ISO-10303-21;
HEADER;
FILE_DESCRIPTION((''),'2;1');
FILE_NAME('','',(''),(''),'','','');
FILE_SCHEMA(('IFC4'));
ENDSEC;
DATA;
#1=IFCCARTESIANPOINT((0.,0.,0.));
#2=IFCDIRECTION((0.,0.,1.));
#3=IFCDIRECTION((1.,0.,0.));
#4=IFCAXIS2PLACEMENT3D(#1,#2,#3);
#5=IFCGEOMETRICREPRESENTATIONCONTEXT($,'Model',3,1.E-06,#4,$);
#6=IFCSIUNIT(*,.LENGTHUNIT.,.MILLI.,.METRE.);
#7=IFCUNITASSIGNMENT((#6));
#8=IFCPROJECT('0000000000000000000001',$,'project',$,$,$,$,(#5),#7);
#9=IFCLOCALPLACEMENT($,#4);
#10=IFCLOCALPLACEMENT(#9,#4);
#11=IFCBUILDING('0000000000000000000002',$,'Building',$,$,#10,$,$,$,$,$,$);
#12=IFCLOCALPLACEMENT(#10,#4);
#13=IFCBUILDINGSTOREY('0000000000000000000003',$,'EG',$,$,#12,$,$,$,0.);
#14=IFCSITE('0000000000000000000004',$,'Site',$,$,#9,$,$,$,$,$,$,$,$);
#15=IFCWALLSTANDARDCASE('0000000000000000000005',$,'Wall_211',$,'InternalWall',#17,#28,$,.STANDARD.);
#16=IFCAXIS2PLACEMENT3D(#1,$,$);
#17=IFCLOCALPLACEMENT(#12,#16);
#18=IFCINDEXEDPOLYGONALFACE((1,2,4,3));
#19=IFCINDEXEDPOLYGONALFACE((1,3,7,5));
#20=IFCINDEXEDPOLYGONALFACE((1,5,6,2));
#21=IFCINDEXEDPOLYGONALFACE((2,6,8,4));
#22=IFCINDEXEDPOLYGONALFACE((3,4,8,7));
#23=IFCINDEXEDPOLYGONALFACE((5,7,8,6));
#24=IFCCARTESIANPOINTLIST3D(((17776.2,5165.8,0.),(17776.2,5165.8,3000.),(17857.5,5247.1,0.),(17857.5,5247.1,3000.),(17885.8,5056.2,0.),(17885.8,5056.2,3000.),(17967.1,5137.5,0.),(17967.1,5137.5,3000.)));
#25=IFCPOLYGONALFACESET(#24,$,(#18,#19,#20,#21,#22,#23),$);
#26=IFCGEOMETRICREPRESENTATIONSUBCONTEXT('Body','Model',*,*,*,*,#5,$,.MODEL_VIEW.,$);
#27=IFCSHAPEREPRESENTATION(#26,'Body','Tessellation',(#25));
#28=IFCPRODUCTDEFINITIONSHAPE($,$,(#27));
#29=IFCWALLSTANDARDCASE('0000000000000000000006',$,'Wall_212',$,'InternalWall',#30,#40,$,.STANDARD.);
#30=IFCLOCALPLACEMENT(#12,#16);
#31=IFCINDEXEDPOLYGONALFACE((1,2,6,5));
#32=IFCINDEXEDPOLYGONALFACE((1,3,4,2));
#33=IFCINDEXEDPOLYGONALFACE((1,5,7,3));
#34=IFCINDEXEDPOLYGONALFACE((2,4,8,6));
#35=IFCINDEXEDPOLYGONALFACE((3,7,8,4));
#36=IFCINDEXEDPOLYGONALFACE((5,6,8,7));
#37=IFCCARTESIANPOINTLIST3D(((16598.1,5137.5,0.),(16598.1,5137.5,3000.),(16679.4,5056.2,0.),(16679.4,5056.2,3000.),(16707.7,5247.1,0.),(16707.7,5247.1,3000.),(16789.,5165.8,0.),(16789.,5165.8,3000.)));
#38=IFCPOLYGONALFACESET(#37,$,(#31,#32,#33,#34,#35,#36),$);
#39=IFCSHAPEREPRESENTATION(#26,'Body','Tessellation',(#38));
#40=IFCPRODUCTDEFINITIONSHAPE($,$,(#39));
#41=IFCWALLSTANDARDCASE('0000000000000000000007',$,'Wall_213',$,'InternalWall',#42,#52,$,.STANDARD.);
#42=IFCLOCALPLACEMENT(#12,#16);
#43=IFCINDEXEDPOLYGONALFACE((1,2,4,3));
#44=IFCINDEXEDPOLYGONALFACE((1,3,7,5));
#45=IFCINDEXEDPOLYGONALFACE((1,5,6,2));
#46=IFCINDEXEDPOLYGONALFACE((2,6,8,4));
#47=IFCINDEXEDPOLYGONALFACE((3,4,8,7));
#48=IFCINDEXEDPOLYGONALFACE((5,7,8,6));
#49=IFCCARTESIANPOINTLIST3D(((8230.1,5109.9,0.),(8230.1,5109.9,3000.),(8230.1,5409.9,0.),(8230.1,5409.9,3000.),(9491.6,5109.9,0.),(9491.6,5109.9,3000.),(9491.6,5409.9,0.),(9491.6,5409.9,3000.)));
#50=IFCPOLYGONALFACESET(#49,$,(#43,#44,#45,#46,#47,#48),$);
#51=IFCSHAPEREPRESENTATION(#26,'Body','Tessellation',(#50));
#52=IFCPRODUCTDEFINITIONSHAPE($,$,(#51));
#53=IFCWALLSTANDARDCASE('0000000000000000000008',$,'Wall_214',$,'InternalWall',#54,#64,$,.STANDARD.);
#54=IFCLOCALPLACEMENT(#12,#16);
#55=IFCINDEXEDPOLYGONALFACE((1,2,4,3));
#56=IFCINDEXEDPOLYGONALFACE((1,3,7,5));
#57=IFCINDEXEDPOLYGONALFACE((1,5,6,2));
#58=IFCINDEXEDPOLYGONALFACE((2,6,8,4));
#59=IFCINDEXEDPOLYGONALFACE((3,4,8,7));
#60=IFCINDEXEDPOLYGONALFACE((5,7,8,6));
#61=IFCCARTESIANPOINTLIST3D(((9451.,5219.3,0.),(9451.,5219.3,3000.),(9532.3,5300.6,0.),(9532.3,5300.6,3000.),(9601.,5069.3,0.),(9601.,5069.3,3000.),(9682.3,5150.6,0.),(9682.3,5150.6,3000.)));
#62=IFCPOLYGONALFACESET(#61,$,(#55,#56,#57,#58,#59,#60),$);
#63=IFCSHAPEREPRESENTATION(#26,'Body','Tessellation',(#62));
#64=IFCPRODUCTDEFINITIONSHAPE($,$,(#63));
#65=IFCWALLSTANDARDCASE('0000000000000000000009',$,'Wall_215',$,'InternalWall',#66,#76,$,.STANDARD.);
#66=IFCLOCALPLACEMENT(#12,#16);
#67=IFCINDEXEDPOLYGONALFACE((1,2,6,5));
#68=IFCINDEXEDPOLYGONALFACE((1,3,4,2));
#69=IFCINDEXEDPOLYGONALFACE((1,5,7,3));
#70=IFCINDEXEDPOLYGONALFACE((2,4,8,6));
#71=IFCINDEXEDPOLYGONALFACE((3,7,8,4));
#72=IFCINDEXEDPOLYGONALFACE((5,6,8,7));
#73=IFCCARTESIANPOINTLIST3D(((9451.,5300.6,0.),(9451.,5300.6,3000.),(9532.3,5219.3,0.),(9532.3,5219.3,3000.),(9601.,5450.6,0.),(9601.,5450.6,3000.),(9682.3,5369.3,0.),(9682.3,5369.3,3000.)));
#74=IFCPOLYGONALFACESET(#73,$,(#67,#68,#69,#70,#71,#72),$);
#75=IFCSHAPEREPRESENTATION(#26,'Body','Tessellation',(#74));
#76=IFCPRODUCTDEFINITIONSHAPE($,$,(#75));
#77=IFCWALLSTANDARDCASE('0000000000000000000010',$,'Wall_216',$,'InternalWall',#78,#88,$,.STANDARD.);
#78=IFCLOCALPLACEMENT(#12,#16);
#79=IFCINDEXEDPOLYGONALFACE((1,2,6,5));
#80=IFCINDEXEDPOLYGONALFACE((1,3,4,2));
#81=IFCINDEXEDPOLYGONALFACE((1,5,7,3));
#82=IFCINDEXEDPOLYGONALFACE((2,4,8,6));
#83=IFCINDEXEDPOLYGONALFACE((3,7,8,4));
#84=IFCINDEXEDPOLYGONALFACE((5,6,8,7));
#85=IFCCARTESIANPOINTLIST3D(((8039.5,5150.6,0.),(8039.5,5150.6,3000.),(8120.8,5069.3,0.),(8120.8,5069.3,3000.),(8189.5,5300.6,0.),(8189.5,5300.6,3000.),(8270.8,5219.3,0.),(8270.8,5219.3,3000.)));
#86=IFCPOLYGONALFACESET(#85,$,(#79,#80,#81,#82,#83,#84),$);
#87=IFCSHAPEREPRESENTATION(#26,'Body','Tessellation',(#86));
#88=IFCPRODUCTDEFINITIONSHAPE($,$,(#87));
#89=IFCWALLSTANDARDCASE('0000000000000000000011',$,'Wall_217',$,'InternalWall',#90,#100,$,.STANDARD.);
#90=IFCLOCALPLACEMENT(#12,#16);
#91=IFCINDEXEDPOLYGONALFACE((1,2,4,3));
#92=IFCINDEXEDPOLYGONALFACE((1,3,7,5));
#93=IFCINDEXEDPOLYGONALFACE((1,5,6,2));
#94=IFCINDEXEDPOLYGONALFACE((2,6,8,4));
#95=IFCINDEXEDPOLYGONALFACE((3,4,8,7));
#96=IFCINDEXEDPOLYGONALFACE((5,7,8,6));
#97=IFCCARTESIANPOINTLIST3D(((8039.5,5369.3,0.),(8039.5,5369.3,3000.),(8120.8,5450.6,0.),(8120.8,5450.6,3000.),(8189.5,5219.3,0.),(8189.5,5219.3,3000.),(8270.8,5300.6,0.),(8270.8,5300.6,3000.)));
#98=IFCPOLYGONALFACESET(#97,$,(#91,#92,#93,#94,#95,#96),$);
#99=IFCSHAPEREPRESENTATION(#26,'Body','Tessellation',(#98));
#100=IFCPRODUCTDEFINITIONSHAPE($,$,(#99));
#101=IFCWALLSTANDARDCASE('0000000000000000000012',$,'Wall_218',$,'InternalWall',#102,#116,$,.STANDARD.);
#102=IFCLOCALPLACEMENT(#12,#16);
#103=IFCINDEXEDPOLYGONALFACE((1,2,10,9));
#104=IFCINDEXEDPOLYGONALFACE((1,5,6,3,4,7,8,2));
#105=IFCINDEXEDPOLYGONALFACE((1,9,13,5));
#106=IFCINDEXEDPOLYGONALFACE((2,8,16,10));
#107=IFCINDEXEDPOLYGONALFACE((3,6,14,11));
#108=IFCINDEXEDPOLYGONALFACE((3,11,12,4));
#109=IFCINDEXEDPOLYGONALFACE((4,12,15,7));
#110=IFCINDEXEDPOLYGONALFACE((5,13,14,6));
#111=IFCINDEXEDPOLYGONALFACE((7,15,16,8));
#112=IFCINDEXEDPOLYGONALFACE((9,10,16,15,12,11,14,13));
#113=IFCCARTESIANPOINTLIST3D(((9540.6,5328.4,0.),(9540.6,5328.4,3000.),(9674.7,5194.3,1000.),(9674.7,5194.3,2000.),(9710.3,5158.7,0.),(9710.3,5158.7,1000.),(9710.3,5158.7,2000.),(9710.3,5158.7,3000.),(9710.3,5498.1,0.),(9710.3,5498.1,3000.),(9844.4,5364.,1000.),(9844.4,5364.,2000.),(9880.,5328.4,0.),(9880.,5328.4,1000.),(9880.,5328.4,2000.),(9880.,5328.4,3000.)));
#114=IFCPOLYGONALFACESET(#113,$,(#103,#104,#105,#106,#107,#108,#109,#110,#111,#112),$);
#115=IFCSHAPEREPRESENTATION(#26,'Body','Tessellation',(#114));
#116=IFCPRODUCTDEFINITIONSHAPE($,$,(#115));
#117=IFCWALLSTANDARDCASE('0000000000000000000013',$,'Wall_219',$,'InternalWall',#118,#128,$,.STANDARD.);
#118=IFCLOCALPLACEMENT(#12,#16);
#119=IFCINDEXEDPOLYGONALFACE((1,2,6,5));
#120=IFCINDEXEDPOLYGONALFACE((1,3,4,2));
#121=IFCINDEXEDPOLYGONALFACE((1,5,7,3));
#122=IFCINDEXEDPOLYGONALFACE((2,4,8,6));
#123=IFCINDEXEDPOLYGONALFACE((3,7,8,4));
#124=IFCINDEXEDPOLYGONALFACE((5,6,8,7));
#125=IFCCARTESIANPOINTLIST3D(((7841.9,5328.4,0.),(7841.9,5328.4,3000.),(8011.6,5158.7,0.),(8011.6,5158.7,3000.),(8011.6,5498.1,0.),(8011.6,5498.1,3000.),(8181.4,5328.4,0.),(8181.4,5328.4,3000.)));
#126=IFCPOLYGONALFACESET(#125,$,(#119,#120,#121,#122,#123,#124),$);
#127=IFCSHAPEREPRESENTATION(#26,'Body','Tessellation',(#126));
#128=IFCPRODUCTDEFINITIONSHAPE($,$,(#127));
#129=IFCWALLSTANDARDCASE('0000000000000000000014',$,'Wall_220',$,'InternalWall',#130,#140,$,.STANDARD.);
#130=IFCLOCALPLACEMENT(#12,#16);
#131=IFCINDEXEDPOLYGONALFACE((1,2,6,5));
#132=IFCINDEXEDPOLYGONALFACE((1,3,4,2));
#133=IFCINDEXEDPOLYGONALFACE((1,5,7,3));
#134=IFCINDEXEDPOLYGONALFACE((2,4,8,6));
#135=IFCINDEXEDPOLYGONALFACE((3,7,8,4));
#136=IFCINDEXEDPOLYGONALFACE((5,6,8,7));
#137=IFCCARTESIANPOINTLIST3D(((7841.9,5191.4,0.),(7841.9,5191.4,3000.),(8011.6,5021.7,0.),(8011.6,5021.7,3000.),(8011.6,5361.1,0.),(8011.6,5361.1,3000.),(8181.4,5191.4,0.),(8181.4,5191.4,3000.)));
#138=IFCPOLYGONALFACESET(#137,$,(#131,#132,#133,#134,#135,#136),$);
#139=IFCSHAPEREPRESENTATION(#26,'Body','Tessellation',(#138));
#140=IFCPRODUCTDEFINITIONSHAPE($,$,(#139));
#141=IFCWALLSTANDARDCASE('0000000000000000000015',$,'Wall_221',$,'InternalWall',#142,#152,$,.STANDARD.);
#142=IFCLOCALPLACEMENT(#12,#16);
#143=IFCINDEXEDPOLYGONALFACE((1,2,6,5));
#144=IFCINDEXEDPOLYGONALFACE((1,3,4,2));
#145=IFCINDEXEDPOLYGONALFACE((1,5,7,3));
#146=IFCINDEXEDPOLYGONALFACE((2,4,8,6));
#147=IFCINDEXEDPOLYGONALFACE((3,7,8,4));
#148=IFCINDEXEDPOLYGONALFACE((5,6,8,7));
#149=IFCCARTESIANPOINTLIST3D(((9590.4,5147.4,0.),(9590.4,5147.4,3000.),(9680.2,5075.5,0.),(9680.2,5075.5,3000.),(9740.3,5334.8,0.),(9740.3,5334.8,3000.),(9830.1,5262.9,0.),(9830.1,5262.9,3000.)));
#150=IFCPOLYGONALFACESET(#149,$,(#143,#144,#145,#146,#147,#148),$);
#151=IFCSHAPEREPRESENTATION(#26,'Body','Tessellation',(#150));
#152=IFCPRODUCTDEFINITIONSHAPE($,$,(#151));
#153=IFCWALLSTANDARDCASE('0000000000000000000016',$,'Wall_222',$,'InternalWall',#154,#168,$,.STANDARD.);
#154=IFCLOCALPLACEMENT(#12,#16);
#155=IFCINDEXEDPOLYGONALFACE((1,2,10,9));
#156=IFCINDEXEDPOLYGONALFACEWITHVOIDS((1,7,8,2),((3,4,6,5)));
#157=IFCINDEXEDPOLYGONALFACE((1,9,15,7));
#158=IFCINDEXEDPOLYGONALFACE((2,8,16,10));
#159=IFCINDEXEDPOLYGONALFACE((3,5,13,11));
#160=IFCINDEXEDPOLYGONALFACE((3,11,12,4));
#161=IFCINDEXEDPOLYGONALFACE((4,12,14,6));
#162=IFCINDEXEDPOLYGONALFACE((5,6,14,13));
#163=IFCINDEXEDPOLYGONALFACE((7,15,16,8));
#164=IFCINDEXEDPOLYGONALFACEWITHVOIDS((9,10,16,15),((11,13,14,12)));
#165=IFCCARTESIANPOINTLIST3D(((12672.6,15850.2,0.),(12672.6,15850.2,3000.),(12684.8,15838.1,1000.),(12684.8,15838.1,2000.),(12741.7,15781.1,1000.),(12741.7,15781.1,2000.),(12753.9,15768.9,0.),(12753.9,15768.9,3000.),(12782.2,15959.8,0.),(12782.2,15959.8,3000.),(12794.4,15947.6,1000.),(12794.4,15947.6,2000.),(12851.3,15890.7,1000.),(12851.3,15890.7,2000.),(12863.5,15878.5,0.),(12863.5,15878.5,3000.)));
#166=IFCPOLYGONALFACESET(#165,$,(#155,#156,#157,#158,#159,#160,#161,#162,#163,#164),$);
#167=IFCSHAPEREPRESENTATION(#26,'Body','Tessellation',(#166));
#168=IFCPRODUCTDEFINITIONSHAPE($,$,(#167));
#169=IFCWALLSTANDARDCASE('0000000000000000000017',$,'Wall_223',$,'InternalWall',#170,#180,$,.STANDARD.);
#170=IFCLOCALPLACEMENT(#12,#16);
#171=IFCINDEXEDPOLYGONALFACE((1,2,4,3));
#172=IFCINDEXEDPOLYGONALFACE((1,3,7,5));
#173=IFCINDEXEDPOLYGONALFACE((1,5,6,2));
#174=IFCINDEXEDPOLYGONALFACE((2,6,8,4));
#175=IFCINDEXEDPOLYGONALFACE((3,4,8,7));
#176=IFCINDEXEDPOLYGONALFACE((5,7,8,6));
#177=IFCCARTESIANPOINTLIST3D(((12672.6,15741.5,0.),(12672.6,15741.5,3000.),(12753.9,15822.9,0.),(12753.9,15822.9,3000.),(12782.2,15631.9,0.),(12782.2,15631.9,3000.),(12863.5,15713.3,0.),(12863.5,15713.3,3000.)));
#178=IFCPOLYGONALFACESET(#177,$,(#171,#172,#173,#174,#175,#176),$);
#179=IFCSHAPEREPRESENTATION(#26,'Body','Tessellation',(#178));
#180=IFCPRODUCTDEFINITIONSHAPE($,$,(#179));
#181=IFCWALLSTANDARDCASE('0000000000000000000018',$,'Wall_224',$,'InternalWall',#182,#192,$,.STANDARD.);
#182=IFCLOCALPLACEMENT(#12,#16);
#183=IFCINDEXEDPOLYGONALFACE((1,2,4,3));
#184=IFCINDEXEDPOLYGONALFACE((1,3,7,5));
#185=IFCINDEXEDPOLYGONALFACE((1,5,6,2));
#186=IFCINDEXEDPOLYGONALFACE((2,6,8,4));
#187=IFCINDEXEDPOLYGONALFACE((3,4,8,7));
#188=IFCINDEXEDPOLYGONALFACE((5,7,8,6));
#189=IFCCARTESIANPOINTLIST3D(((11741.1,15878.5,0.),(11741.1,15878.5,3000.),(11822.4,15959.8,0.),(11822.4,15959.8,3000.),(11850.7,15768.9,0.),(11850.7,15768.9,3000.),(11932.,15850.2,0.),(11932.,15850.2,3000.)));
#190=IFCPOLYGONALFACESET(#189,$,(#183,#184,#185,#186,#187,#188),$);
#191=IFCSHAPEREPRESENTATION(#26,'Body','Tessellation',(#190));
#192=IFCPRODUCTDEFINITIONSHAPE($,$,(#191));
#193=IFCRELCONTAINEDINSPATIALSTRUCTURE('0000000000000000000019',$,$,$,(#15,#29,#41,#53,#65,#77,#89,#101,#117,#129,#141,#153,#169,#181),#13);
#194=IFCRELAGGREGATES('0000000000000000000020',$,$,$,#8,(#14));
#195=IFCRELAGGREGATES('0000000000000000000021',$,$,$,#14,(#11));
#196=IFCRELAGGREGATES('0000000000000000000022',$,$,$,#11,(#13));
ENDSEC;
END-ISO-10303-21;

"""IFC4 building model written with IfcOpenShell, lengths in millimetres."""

from ifc_helpers import new_model, si_unit, frame, origin_with_axes, place, context, subcontext, project, spatial, rectangle, extrude, element, save


model = new_model("IFC4")

# Units and contexts
model_context = context("Model", 3, precision=1e-06, world=origin_with_axes())
body_context = subcontext(model_context, "Body", "Model", "MODEL_VIEW")
ifc_project = project(units=[si_unit("LENGTHUNIT", "METRE", prefix="MILLI")], contexts=[model_context])

# Site, building, storey
site_placement = place(None, origin_with_axes())
site = spatial("IfcSite", under=ifc_project, at=site_placement, Name="Site")
building_placement = place(site_placement, origin_with_axes())
building = spatial("IfcBuilding", under=site, at=building_placement, Name="Building")
storey_placement = place(building_placement, origin_with_axes())
storey = spatial("IfcBuildingStorey", under=building, at=storey_placement, Name="EG", Elevation=0.0)

# Walls
wall_1_placement = place(storey_placement, origin_with_axes())
element("IfcWallStandardCase", 1, at=wall_1_placement, inside=storey, Name="Wall_211", ObjectType="InternalWall", PredefinedType="STANDARD", context=body_context, shape_type="SweptSolid", body=[
    extrude(rectangle(XDim=155.0, YDim=115.0), frame((17871.7, 5151.6, 0.0), z_axis=(0.0, 0.0, 1.0), x_axis=(-0.707107, 0.707107, 0.0)), (0.0, 0.0, 1.0), 3000.0),
])
wall_2_placement = place(storey_placement, origin_with_axes())
element("IfcWallStandardCase", 2, at=wall_2_placement, inside=storey, Name="Wall_212", ObjectType="InternalWall", PredefinedType="STANDARD", context=body_context, shape_type="SweptSolid", body=[
    extrude(rectangle(XDim=155.0, YDim=115.0), frame((16693.6, 5151.6, 0.0), z_axis=(0.0, 0.0, 1.0), x_axis=(-0.707107, -0.707107, 0.0)), (0.0, 0.0, 1.0), 3000.0),
])
wall_3_placement = place(storey_placement, origin_with_axes())
element("IfcWallStandardCase", 3, at=wall_3_placement, inside=storey, Name="Wall_213", ObjectType="InternalWall", PredefinedType="STANDARD", context=body_context, shape_type="SweptSolid", body=[
    extrude(rectangle(XDim=1261.5, YDim=300.0), frame((8860.9, 5259.9, 0.0), z_axis=(0.0, 0.0, 1.0), x_axis=(-1.0, 0.0, 0.0)), (0.0, 0.0, 1.0), 3000.0),
])
wall_4_placement = place(storey_placement, origin_with_axes())
element("IfcWallStandardCase", 4, at=wall_4_placement, inside=storey, Name="Wall_214", ObjectType="InternalWall", PredefinedType="STANDARD", context=body_context, shape_type="SweptSolid", body=[
    extrude(rectangle(XDim=212.1, YDim=115.0), frame((9566.6, 5184.9, 0.0), z_axis=(0.0, 0.0, 1.0), x_axis=(0.707107, -0.707107, 0.0)), (0.0, 0.0, 1.0), 3000.0),
])
wall_5_placement = place(storey_placement, origin_with_axes())
element("IfcWallStandardCase", 5, at=wall_5_placement, inside=storey, Name="Wall_215", ObjectType="InternalWall", PredefinedType="STANDARD", context=body_context, shape_type="SweptSolid", body=[
    extrude(rectangle(XDim=212.1, YDim=115.0), frame((9566.6, 5334.9, 0.0), z_axis=(0.0, 0.0, 1.0), x_axis=(0.707107, 0.707107, 0.0)), (0.0, 0.0, 1.0), 3000.0),
])
wall_6_placement = place(storey_placement, origin_with_axes())
element("IfcWallStandardCase", 6, at=wall_6_placement, inside=storey, Name="Wall_216", ObjectType="InternalWall", PredefinedType="STANDARD", context=body_context, shape_type="SweptSolid", body=[
    extrude(rectangle(XDim=212.1, YDim=115.0), frame((8155.1, 5184.9, 0.0), z_axis=(0.0, 0.0, 1.0), x_axis=(-0.707107, -0.707107, 0.0)), (0.0, 0.0, 1.0), 3000.0),
])
wall_7_placement = place(storey_placement, origin_with_axes())
element("IfcWallStandardCase", 7, at=wall_7_placement, inside=storey, Name="Wall_217", ObjectType="InternalWall", PredefinedType="STANDARD", context=body_context, shape_type="SweptSolid", body=[
    extrude(rectangle(XDim=212.1, YDim=115.0), frame((8155.1, 5334.9, 0.0), z_axis=(0.0, 0.0, 1.0), x_axis=(-0.707107, 0.707107, 0.0)), (0.0, 0.0, 1.0), 3000.0),
])

# Wall, opening
wall_8_placement = place(storey_placement, origin_with_axes())
wall_8 = element("IfcWallStandardCase", 8, at=wall_8_placement, inside=storey, Name="Wall_218", ObjectType="InternalWall", PredefinedType="STANDARD", context=body_context, shape_type="SweptSolid", body=[
    extrude(rectangle(XDim=240.0, YDim=240.0), frame((9710.3, 5328.4, 0.0), z_axis=(0.0, 0.0, 1.0), x_axis=(-0.707107, 0.707107, 0.0)), (0.0, 0.0, 1.0), 3000.0),
])
opening_1_placement = place(wall_8_placement, origin_with_axes())
element("IfcOpeningElement", 9, at=opening_1_placement, inside=storey, cuts=wall_8, context=body_context, shape_type="SweptSolid", body=[
    extrude(rectangle(XDim=1186.4, YDim=240.0), frame((10179.0, 4859.7, 1000.0), z_axis=(0.0, 0.0, 1.0), x_axis=(-0.707107, 0.707107, 0.0)), (0.0, 0.0, 1.0), 1000.0),
])

# Walls
wall_9_placement = place(storey_placement, origin_with_axes())
element("IfcWallStandardCase", 10, at=wall_9_placement, inside=storey, Name="Wall_219", ObjectType="InternalWall", PredefinedType="STANDARD", context=body_context, shape_type="SweptSolid", body=[
    extrude(rectangle(XDim=240.0, YDim=240.0), frame((8011.6, 5328.4, 0.0), z_axis=(0.0, 0.0, 1.0), x_axis=(-0.707107, -0.707107, 0.0)), (0.0, 0.0, 1.0), 3000.0),
])
wall_10_placement = place(storey_placement, origin_with_axes())
element("IfcWallStandardCase", 11, at=wall_10_placement, inside=storey, Name="Wall_220", ObjectType="InternalWall", PredefinedType="STANDARD", context=body_context, shape_type="SweptSolid", body=[
    extrude(rectangle(XDim=240.0, YDim=240.0), frame((8011.6, 5191.4, 0.0), z_axis=(0.0, 0.0, 1.0), x_axis=(-0.707107, 0.707107, 0.0)), (0.0, 0.0, 1.0), 3000.0),
])
wall_11_placement = place(storey_placement, origin_with_axes())
element("IfcWallStandardCase", 12, at=wall_11_placement, inside=storey, Name="Wall_221", ObjectType="InternalWall", PredefinedType="STANDARD", context=body_context, shape_type="SweptSolid", body=[
    extrude(rectangle(XDim=240.0, YDim=115.0), frame((9710.3, 5205.1, 0.0), z_axis=(0.0, 0.0, 1.0), x_axis=(0.624695, 0.780869, 0.0)), (0.0, 0.0, 1.0), 3000.0),
])

# Wall, opening
wall_12_placement = place(storey_placement, origin_with_axes())
wall_12 = element("IfcWallStandardCase", 13, at=wall_12_placement, inside=storey, Name="Wall_222", ObjectType="InternalWall", PredefinedType="STANDARD", context=body_context, shape_type="SweptSolid", body=[
    extrude(rectangle(XDim=155.0, YDim=115.0), frame((12768.1, 15864.4, 0.0), z_axis=(0.0, 0.0, 1.0), x_axis=(-0.707107, -0.707107, 0.0)), (0.0, 0.0, 1.0), 3000.0),
])
opening_2_placement = place(wall_12_placement, origin_with_axes())
element("IfcOpeningElement", 14, at=opening_2_placement, inside=storey, cuts=wall_12, context=body_context, shape_type="SweptSolid", body=[
    extrude(rectangle(XDim=1067.6, YDim=80.5), frame((13081.7, 16178.0, 1000.0), z_axis=(0.0, 0.0, 1.0), x_axis=(-0.707107, -0.707107, 0.0)), (0.0, 0.0, 1.0), 1000.0),
])

# Walls
wall_13_placement = place(storey_placement, origin_with_axes())
element("IfcWallStandardCase", 15, at=wall_13_placement, inside=storey, Name="Wall_223", ObjectType="InternalWall", PredefinedType="STANDARD", context=body_context, shape_type="SweptSolid", body=[
    extrude(rectangle(XDim=155.0, YDim=115.0), frame((12768.1, 15727.4, 0.0), z_axis=(0.0, 0.0, 1.0), x_axis=(0.707107, -0.707107, 0.0)), (0.0, 0.0, 1.0), 3000.0),
])
wall_14_placement = place(storey_placement, origin_with_axes())
element("IfcWallStandardCase", 16, at=wall_14_placement, inside=storey, Name="Wall_224", ObjectType="InternalWall", PredefinedType="STANDARD", context=body_context, shape_type="SweptSolid", body=[
    extrude(rectangle(XDim=155.0, YDim=115.0), frame((11836.6, 15864.4, 0.0), z_axis=(0.0, 0.0, 1.0), x_axis=(0.707107, -0.707107, 0.0)), (0.0, 0.0, 1.0), 3000.0),
])

save(model, "model.ifc")
